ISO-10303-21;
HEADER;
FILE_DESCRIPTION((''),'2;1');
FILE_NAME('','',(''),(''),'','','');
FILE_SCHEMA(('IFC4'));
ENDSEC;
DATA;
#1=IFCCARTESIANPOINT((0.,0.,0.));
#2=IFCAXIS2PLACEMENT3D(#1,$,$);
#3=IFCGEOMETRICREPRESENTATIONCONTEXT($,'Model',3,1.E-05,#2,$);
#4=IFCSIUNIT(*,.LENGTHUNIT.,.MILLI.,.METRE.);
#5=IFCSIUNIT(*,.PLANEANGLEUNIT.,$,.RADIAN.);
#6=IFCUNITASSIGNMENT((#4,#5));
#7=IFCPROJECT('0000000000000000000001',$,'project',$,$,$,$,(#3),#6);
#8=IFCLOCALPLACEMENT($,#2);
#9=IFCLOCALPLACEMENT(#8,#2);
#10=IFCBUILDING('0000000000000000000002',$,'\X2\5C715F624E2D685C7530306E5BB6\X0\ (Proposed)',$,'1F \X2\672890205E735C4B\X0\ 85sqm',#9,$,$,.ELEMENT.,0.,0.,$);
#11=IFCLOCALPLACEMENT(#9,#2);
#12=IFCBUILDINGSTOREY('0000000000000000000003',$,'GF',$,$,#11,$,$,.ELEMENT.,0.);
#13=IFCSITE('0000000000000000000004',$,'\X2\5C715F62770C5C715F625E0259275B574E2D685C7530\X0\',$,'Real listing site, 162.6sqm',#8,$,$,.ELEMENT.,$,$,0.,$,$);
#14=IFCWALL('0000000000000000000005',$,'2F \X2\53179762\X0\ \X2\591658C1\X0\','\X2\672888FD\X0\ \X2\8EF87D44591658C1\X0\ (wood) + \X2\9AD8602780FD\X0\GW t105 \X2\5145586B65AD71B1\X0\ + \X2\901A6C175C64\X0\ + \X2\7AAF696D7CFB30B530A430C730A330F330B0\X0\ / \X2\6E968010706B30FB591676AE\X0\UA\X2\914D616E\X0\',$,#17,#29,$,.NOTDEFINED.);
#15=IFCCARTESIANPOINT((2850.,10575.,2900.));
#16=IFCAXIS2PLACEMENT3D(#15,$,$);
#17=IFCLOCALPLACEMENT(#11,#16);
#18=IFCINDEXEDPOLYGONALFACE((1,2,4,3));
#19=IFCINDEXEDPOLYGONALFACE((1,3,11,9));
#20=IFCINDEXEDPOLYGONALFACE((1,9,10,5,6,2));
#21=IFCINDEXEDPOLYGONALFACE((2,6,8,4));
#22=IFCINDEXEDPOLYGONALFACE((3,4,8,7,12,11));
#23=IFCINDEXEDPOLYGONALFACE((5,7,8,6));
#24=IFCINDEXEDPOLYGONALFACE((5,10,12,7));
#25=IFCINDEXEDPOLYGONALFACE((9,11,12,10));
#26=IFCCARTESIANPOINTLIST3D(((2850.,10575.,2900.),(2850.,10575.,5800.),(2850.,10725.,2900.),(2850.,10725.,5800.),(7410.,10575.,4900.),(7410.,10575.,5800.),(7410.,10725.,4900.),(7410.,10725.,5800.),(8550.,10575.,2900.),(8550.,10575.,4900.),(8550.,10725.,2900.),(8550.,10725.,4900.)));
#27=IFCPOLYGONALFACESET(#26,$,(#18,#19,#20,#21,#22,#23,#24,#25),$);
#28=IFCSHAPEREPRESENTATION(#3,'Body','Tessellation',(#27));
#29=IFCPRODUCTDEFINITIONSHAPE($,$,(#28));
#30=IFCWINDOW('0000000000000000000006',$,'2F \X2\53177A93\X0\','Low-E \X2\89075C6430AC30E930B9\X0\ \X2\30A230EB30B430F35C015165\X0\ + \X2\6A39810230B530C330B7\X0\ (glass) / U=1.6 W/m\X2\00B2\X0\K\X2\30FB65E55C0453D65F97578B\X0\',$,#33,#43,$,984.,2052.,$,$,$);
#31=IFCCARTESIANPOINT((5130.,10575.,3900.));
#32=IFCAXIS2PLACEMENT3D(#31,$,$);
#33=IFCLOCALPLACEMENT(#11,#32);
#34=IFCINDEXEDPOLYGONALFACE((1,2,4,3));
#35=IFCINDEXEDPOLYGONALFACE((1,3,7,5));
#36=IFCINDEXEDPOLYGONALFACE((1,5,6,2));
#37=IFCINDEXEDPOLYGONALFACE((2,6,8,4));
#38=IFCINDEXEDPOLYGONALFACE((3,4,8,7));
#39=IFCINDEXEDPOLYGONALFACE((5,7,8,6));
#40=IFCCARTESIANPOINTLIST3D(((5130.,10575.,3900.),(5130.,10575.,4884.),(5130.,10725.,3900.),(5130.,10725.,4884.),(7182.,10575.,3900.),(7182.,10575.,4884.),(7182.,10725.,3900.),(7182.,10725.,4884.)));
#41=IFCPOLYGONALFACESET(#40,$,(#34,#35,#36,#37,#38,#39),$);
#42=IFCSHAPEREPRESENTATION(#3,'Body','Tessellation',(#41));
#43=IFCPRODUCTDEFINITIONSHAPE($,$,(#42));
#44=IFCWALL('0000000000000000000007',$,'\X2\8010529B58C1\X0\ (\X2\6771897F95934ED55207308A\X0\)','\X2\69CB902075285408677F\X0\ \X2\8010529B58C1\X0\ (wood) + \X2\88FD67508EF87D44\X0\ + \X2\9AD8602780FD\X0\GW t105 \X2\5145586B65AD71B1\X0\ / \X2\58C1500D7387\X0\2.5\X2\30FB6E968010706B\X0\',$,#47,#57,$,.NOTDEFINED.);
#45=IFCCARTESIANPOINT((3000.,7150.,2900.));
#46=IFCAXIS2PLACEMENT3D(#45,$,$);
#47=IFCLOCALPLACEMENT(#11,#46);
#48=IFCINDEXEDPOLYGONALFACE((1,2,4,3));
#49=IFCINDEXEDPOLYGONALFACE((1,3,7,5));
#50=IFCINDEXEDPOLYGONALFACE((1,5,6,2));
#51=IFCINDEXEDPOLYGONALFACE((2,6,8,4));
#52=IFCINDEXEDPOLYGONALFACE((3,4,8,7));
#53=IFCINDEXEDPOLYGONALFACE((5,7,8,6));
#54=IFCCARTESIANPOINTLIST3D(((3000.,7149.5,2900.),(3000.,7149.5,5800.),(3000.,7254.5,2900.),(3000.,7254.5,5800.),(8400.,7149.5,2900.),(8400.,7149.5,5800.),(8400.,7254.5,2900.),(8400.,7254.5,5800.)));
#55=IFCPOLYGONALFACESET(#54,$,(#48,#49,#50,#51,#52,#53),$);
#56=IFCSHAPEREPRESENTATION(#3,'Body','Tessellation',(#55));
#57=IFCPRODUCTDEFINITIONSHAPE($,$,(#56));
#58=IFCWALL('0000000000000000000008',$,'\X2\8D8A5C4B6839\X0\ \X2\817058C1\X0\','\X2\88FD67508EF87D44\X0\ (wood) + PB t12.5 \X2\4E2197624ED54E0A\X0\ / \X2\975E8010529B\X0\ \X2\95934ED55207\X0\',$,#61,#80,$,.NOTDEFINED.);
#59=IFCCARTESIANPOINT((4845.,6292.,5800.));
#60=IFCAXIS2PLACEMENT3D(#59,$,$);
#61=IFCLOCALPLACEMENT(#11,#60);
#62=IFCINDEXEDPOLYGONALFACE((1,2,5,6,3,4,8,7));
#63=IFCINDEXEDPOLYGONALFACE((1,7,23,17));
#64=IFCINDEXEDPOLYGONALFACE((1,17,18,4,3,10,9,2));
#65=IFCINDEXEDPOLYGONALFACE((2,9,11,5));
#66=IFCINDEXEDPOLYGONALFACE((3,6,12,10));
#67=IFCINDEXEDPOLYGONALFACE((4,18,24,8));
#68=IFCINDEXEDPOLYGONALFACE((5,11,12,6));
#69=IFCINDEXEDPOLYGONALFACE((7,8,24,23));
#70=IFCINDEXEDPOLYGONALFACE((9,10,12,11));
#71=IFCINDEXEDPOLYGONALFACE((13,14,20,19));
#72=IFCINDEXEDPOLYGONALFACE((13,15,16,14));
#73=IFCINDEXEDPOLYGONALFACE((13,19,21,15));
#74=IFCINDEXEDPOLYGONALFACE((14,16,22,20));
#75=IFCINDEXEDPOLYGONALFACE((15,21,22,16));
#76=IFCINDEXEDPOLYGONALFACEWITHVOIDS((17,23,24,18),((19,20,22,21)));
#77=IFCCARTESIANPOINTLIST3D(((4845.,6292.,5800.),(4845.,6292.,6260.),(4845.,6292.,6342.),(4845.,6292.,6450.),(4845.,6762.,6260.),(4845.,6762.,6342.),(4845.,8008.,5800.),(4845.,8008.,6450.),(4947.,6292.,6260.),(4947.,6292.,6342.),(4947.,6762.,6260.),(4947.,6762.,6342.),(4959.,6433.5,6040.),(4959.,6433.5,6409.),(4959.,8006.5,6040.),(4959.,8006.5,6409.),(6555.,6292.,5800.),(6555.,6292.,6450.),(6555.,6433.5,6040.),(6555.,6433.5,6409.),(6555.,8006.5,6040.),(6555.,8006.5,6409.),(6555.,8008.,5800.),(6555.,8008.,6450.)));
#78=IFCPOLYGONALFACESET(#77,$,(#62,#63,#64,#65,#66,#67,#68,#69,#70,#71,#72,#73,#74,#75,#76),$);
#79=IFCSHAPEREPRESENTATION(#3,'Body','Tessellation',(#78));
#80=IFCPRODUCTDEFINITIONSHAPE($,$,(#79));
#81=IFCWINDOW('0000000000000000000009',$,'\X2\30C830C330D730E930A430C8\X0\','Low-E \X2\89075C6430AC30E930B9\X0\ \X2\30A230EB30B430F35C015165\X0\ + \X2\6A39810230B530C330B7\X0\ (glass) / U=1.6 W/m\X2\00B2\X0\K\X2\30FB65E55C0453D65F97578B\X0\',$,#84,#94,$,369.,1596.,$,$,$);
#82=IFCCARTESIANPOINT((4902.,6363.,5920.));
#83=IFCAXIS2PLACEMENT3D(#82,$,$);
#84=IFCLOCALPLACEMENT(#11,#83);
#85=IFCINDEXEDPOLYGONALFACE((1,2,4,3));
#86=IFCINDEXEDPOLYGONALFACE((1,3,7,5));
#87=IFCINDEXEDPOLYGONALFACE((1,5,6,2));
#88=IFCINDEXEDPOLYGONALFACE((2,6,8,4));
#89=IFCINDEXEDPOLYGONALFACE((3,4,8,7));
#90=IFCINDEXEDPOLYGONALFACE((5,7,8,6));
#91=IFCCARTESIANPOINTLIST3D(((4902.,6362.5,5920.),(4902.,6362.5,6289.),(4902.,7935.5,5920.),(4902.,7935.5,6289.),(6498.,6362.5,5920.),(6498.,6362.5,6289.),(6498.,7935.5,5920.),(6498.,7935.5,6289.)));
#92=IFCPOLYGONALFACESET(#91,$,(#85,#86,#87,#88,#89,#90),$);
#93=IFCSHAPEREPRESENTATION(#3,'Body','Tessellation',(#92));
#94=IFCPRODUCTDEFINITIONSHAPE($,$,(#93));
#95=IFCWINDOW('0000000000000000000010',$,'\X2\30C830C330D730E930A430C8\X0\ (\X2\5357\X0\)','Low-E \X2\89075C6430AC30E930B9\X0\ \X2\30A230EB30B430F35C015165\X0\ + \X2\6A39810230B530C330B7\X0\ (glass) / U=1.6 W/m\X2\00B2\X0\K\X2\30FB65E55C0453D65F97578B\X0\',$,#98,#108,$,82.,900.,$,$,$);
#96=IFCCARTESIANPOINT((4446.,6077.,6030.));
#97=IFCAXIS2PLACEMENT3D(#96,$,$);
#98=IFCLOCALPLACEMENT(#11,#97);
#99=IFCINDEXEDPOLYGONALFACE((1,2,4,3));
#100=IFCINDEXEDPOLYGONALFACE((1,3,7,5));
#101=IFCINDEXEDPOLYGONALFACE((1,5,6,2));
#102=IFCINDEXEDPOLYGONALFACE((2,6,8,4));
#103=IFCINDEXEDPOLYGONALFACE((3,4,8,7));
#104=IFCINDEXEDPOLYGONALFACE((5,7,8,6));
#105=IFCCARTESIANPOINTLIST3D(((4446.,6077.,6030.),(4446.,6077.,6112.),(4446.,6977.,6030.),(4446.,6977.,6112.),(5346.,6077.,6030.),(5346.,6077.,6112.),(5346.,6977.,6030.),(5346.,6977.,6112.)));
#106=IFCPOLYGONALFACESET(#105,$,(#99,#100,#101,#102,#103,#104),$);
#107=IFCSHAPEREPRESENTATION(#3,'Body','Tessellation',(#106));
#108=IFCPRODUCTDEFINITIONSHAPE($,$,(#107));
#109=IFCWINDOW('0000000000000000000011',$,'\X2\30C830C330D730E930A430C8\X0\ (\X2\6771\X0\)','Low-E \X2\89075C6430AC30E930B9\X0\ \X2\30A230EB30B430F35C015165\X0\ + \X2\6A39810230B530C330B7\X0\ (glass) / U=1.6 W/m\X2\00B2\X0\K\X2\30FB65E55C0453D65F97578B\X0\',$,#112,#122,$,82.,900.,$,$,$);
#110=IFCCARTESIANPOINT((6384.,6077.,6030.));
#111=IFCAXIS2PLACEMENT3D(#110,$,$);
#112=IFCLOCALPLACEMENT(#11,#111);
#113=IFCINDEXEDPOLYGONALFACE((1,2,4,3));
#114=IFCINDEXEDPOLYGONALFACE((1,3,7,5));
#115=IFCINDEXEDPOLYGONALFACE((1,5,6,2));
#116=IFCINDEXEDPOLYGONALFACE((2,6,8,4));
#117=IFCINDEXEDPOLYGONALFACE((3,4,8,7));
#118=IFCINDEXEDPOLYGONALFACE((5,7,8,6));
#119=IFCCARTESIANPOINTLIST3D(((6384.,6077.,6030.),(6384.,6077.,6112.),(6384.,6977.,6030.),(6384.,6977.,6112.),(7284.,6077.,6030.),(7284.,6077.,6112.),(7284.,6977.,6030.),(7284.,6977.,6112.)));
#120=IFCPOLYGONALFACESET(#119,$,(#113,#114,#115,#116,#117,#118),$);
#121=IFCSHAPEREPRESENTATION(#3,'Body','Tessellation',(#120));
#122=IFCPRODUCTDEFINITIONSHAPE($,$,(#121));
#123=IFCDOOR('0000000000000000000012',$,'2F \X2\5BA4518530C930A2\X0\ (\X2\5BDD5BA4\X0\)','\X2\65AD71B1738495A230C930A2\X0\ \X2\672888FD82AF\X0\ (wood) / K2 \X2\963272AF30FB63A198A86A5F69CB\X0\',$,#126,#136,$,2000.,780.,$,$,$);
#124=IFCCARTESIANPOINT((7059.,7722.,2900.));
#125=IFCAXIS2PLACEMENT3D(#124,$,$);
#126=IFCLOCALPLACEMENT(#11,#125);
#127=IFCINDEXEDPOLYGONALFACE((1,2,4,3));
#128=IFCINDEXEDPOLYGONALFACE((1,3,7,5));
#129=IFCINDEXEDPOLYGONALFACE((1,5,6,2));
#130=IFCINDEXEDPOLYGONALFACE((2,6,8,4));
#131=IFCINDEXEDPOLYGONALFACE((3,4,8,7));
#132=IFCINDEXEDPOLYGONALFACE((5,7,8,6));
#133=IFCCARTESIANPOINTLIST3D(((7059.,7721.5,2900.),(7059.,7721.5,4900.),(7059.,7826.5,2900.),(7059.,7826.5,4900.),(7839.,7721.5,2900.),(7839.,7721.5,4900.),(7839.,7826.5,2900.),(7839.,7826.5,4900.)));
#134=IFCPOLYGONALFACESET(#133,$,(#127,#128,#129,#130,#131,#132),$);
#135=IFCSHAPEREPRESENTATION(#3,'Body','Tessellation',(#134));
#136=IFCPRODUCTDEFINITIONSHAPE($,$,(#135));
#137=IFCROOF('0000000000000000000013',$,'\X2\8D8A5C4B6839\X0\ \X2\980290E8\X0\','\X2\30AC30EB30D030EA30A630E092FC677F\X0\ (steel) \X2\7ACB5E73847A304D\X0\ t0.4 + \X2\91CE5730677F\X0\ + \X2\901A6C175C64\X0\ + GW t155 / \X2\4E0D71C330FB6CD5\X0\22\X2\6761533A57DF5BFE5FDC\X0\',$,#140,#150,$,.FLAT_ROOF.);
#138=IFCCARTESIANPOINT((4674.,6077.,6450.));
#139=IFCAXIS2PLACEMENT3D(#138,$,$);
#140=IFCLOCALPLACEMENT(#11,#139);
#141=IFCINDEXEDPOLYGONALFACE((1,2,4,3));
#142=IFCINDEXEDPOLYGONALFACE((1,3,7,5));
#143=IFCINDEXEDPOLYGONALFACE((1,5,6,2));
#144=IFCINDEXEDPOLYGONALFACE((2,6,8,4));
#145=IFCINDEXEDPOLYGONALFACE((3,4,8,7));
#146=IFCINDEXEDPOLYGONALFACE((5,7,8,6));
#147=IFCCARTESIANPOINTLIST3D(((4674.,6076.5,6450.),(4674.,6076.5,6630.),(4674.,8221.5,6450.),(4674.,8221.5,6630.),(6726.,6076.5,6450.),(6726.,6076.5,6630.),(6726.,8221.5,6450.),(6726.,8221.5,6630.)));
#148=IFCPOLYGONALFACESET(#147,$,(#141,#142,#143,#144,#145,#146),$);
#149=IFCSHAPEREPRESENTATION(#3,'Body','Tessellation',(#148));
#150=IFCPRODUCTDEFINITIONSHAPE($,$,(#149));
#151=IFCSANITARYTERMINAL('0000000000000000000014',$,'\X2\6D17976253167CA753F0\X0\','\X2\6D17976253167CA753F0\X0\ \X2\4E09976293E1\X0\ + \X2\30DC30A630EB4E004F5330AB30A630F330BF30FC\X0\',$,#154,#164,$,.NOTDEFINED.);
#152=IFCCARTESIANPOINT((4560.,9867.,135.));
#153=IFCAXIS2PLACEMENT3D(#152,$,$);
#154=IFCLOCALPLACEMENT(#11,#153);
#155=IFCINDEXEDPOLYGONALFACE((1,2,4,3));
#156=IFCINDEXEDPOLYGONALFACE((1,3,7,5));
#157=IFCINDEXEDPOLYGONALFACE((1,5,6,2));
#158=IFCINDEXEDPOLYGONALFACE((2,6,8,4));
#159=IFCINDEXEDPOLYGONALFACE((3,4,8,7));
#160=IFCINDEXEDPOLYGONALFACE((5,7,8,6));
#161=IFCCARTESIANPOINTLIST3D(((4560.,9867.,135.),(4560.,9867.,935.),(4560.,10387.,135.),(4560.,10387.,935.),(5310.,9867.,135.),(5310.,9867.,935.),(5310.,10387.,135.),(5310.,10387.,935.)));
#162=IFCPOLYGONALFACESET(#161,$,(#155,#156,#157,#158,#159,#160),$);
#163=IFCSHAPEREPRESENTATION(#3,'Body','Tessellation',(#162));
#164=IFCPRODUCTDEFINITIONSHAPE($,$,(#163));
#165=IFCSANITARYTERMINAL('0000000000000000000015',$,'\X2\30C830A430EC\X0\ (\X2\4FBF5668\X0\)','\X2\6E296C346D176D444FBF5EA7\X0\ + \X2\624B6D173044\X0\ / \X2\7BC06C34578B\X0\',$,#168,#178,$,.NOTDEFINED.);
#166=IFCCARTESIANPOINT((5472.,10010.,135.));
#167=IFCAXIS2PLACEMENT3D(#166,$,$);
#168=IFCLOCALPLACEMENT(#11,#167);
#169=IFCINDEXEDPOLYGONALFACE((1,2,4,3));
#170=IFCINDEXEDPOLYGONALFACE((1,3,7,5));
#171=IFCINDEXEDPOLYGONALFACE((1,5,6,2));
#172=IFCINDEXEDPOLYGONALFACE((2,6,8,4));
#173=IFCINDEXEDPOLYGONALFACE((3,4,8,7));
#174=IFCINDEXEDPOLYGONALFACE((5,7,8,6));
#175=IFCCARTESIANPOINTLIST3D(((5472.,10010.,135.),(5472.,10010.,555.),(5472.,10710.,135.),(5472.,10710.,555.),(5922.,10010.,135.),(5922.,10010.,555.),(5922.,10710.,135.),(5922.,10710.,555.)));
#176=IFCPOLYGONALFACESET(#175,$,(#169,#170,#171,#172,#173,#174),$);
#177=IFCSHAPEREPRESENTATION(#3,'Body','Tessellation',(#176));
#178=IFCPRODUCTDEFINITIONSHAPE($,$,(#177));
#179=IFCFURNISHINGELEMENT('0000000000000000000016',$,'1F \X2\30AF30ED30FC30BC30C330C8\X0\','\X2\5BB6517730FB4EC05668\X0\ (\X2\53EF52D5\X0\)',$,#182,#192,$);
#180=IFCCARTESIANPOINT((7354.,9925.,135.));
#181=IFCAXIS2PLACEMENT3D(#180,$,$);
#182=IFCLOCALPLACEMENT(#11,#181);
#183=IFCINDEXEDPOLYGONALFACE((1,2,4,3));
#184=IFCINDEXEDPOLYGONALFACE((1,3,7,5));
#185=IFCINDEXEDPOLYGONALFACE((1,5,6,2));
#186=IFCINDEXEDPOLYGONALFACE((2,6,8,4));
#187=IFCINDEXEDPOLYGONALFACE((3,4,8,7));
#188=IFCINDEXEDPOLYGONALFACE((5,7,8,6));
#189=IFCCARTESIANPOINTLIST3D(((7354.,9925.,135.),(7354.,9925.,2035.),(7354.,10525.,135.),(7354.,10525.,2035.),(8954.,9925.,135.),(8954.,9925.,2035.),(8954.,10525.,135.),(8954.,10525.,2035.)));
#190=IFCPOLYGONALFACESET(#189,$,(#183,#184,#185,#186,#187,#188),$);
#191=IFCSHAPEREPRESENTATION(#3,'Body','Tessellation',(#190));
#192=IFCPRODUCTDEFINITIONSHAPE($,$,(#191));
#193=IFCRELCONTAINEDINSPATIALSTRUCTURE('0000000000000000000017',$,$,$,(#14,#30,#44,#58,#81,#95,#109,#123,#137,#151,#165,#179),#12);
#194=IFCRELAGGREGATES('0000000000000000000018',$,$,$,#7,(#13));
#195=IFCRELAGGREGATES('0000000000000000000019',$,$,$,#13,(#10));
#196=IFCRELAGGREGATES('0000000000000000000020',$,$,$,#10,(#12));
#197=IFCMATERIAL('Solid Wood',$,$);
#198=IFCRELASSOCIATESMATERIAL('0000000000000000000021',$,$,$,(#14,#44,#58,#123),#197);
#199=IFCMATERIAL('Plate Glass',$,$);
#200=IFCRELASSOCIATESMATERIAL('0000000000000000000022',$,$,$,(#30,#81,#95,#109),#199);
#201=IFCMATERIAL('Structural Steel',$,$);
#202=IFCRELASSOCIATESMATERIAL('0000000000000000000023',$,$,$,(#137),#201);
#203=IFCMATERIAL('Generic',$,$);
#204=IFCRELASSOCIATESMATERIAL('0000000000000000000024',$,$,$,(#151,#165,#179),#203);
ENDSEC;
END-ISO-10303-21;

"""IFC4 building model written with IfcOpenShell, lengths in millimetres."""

from ifc_helpers import new_model, si_unit, frame, frame_2d, origin, place, context, project, spatial, rectangle, extrude, material, element, fill, save


model = new_model("IFC4")

# Units and contexts
model_context = context("Model", 3, precision=1e-05, world=origin())
ifc_project = project(units=[si_unit("LENGTHUNIT", "METRE", prefix="MILLI"), si_unit("PLANEANGLEUNIT", "RADIAN")], contexts=[model_context])

# Site, building, storey
site_placement = place(None, origin())
site = spatial("IfcSite", under=ifc_project, at=site_placement, Name="山形県山形市大字中桜田", ObjectType="Real listing site, 162.6sqm", CompositionType="ELEMENT", RefElevation=0.0)
building_placement = place(site_placement, origin())
building = spatial("IfcBuilding", under=site, at=building_placement, Name="山形中桜田の家 (Proposed)", ObjectType="1F 木造平屋 85sqm", CompositionType="ELEMENT", ElevationOfRefHeight=0.0, ElevationOfTerrain=0.0)
storey_placement = place(building_placement, origin())
storey = spatial("IfcBuildingStorey", under=building, at=storey_placement, Name="GF", CompositionType="ELEMENT", Elevation=0.0)

# Wall, opening, window
ifc_material_1 = material(Name="Solid Wood")
wall_1_placement = place(storey_placement, frame((2850.0, 10575.0, 2900.0)))
wall_1 = element("IfcWall", 1, at=wall_1_placement, inside=storey, material=ifc_material_1, Name="2F 北面 外壁", Description="木製 軸組外壁 (wood) + 高性能GW t105 充填断熱 + 通気層 + 窯業系サイディング / 準耐火・外皮UA配慮", PredefinedType="NOTDEFINED", context=model_context, shape_type="SweptSolid", body=[
    extrude(rectangle(XDim=5700.0, YDim=150.0, at=frame_2d((2850.0, 75.0))), frame((2850.0, 10575.0, 2900.0)), (0.0, 0.0, 1.0), 2900.0),
])
opening_1_placement = place(storey_placement, frame((5130.0, 10575.0, 3900.0)))
opening_1 = element("IfcOpeningElement", 2, at=opening_1_placement, cuts=wall_1, PredefinedType="NOTDEFINED", context=model_context, shape_type="SweptSolid", body=[
    extrude(rectangle(XDim=2052.0, YDim=150.0, at=frame_2d((1026.0, 75.0))), frame((5130.0, 10575.0, 3900.0)), (0.0, 0.0, 1.0), 984.0),
])
ifc_material_2 = material(Name="Plate Glass")
window_1_placement = place(storey_placement, frame((5130.0, 10575.0, 3900.0)))
window_1 = element("IfcWindow", 3, at=window_1_placement, inside=storey, material=ifc_material_2, Name="2F 北窓", Description="Low-E 複層ガラス アルゴン封入 + 樹脂サッシ (glass) / U=1.6 W/m²K・日射取得型", OverallHeight=984.0, OverallWidth=2052.0, context=model_context, shape_type="SweptSolid", body=[
    extrude(rectangle(XDim=2052.0, YDim=150.0, at=frame_2d((1026.0, 75.0))), frame((5130.0, 10575.0, 3900.0)), (0.0, 0.0, 1.0), 984.0),
])
fill(opening_1, window_1)

# Wall
wall_2_placement = place(storey_placement, frame((3000.0, 7150.0, 2900.0)))
element("IfcWall", 4, at=wall_2_placement, inside=storey, material=ifc_material_1, Name="耐力壁 (東西間仕切り)", Description="構造用合板 耐力壁 (wood) + 製材軸組 + 高性能GW t105 充填断熱 / 壁倍率2.5・準耐火", PredefinedType="NOTDEFINED", context=model_context, shape_type="SweptSolid", body=[
    extrude(rectangle(XDim=5400.0, YDim=105.0, at=frame_2d((2700.0, 52.0))), frame((3000.0, 7150.0, 2900.0)), (0.0, 0.0, 1.0), 2900.0),
])

# Wall, openings, windows
wall_3_placement = place(storey_placement, frame((4845.0, 6292.0, 5800.0)))
wall_3 = element("IfcWall", 5, at=wall_3_placement, inside=storey, material=ifc_material_1, Name="越屋根 腰壁", Description="製材軸組 (wood) + PB t12.5 両面仕上 / 非耐力 間仕切", PredefinedType="NOTDEFINED", context=model_context, shape_type="SweptSolid", body=[
    extrude(rectangle(XDim=1710.0, YDim=1716.0, at=frame_2d((855.0, 858.0))), frame((4845.0, 6292.0, 5800.0)), (0.0, 0.0, 1.0), 650.0),
])
opening_2_placement = place(storey_placement, frame((4902.0, 6363.0, 5920.0)))
opening_2 = element("IfcOpeningElement", 6, at=opening_2_placement, cuts=wall_3, PredefinedType="NOTDEFINED", context=model_context, shape_type="SweptSolid", body=[
    extrude(rectangle(XDim=1596.0, YDim=1573.0, at=frame_2d((798.0, 786.0))), frame((4902.0, 6363.0, 5920.0)), (0.0, 0.0, 1.0), 369.0),
])
opening_3_placement = place(storey_placement, frame((4446.0, 6077.0, 6030.0)))
opening_3 = element("IfcOpeningElement", 7, at=opening_3_placement, cuts=wall_3, PredefinedType="NOTDEFINED", context=model_context, shape_type="SweptSolid", body=[
    extrude(rectangle(XDim=900.0, YDim=900.0, at=frame_2d((450.0, 450.0))), frame((4446.0, 6077.0, 6030.0)), (0.0, 0.0, 1.0), 82.0),
])
opening_4_placement = place(storey_placement, frame((6384.0, 6077.0, 6030.0)))
opening_4 = element("IfcOpeningElement", 8, at=opening_4_placement, cuts=wall_3, PredefinedType="NOTDEFINED", context=model_context, shape_type="SweptSolid", body=[
    extrude(rectangle(XDim=900.0, YDim=900.0, at=frame_2d((450.0, 450.0))), frame((6384.0, 6077.0, 6030.0)), (0.0, 0.0, 1.0), 82.0),
])
window_2_placement = place(storey_placement, frame((4902.0, 6363.0, 5920.0)))
window_2 = element("IfcWindow", 9, at=window_2_placement, inside=storey, material=ifc_material_2, Name="トップライト", Description="Low-E 複層ガラス アルゴン封入 + 樹脂サッシ (glass) / U=1.6 W/m²K・日射取得型", OverallHeight=369.0, OverallWidth=1596.0, context=model_context, shape_type="SweptSolid", body=[
    extrude(rectangle(XDim=1596.0, YDim=1573.0, at=frame_2d((798.0, 786.0))), frame((4902.0, 6363.0, 5920.0)), (0.0, 0.0, 1.0), 369.0),
])
fill(opening_2, window_2)
window_3_placement = place(storey_placement, frame((4446.0, 6077.0, 6030.0)))
window_3 = element("IfcWindow", 10, at=window_3_placement, inside=storey, material=ifc_material_2, Name="トップライト (南)", Description="Low-E 複層ガラス アルゴン封入 + 樹脂サッシ (glass) / U=1.6 W/m²K・日射取得型", OverallHeight=82.0, OverallWidth=900.0, context=model_context, shape_type="SweptSolid", body=[
    extrude(rectangle(XDim=900.0, YDim=900.0, at=frame_2d((450.0, 450.0))), frame((4446.0, 6077.0, 6030.0)), (0.0, 0.0, 1.0), 82.0),
])
fill(opening_3, window_3)
window_4_placement = place(storey_placement, frame((6384.0, 6077.0, 6030.0)))
window_4 = element("IfcWindow", 11, at=window_4_placement, inside=storey, material=ifc_material_2, Name="トップライト (東)", Description="Low-E 複層ガラス アルゴン封入 + 樹脂サッシ (glass) / U=1.6 W/m²K・日射取得型", OverallHeight=82.0, OverallWidth=900.0, context=model_context, shape_type="SweptSolid", body=[
    extrude(rectangle(XDim=900.0, YDim=900.0, at=frame_2d((450.0, 450.0))), frame((6384.0, 6077.0, 6030.0)), (0.0, 0.0, 1.0), 82.0),
])
fill(opening_4, window_4)

# Door
door_placement = place(storey_placement, frame((7059.0, 7722.0, 2900.0)))
element("IfcDoor", 12, at=door_placement, inside=storey, material=ifc_material_1, Name="2F 室内ドア (寝室)", Description="断熱玄関ドア 木製芯 (wood) / K2 防犯・採風機構", OverallHeight=2000.0, OverallWidth=780.0, context=model_context, shape_type="SweptSolid", body=[
    extrude(rectangle(XDim=780.0, YDim=105.0, at=frame_2d((390.0, 52.0))), frame((7059.0, 7722.0, 2900.0)), (0.0, 0.0, 1.0), 2000.0),
])

# Roof
ifc_material_3 = material(Name="Structural Steel")
roof_placement = place(storey_placement, frame((4674.0, 6077.0, 6450.0)))
element("IfcRoof", 13, at=roof_placement, inside=storey, material=ifc_material_3, Name="越屋根 頂部", Description="ガルバリウム鋼板 (steel) 立平葺き t0.4 + 野地板 + 通気層 + GW t155 / 不燃・法22条区域対応", PredefinedType="FLAT_ROOF", context=model_context, shape_type="SweptSolid", body=[
    extrude(rectangle(XDim=2052.0, YDim=2145.0, at=frame_2d((1026.0, 1072.0))), frame((4674.0, 6077.0, 6450.0)), (0.0, 0.0, 1.0), 180.0),
])

# Sanitary terminals
ifc_material_4 = material(Name="Generic")
sanitary_terminal_1_placement = place(storey_placement, frame((4560.0, 9867.0, 135.0)))
element("IfcSanitaryTerminal", 14, at=sanitary_terminal_1_placement, inside=storey, material=ifc_material_4, Name="洗面化粧台", Description="洗面化粧台 三面鏡 + ボウル一体カウンター", PredefinedType="NOTDEFINED", context=model_context, shape_type="SweptSolid", body=[
    extrude(rectangle(XDim=750.0, YDim=520.0, at=frame_2d((375.0, 260.0))), frame((4560.0, 9867.0, 135.0)), (0.0, 0.0, 1.0), 800.0),
])
sanitary_terminal_2_placement = place(storey_placement, frame((5472.0, 10010.0, 135.0)))
element("IfcSanitaryTerminal", 15, at=sanitary_terminal_2_placement, inside=storey, material=ifc_material_4, Name="トイレ (便器)", Description="温水洗浄便座 + 手洗い / 節水型", PredefinedType="NOTDEFINED", context=model_context, shape_type="SweptSolid", body=[
    extrude(rectangle(XDim=450.0, YDim=700.0, at=frame_2d((225.0, 350.0))), frame((5472.0, 10010.0, 135.0)), (0.0, 0.0, 1.0), 420.0),
])

# Furnishing element
furnishing_1_placement = place(storey_placement, frame((7354.0, 9925.0, 135.0)))
element("IfcFurnishingElement", 16, at=furnishing_1_placement, inside=storey, material=ifc_material_4, Name="1F クローゼット", Description="家具・什器 (可動)", context=model_context, shape_type="SweptSolid", body=[
    extrude(rectangle(XDim=1600.0, YDim=600.0, at=frame_2d((800.0, 300.0))), frame((7354.0, 9925.0, 135.0)), (0.0, 0.0, 1.0), 1900.0),
])

save(model, "model.ifc")
